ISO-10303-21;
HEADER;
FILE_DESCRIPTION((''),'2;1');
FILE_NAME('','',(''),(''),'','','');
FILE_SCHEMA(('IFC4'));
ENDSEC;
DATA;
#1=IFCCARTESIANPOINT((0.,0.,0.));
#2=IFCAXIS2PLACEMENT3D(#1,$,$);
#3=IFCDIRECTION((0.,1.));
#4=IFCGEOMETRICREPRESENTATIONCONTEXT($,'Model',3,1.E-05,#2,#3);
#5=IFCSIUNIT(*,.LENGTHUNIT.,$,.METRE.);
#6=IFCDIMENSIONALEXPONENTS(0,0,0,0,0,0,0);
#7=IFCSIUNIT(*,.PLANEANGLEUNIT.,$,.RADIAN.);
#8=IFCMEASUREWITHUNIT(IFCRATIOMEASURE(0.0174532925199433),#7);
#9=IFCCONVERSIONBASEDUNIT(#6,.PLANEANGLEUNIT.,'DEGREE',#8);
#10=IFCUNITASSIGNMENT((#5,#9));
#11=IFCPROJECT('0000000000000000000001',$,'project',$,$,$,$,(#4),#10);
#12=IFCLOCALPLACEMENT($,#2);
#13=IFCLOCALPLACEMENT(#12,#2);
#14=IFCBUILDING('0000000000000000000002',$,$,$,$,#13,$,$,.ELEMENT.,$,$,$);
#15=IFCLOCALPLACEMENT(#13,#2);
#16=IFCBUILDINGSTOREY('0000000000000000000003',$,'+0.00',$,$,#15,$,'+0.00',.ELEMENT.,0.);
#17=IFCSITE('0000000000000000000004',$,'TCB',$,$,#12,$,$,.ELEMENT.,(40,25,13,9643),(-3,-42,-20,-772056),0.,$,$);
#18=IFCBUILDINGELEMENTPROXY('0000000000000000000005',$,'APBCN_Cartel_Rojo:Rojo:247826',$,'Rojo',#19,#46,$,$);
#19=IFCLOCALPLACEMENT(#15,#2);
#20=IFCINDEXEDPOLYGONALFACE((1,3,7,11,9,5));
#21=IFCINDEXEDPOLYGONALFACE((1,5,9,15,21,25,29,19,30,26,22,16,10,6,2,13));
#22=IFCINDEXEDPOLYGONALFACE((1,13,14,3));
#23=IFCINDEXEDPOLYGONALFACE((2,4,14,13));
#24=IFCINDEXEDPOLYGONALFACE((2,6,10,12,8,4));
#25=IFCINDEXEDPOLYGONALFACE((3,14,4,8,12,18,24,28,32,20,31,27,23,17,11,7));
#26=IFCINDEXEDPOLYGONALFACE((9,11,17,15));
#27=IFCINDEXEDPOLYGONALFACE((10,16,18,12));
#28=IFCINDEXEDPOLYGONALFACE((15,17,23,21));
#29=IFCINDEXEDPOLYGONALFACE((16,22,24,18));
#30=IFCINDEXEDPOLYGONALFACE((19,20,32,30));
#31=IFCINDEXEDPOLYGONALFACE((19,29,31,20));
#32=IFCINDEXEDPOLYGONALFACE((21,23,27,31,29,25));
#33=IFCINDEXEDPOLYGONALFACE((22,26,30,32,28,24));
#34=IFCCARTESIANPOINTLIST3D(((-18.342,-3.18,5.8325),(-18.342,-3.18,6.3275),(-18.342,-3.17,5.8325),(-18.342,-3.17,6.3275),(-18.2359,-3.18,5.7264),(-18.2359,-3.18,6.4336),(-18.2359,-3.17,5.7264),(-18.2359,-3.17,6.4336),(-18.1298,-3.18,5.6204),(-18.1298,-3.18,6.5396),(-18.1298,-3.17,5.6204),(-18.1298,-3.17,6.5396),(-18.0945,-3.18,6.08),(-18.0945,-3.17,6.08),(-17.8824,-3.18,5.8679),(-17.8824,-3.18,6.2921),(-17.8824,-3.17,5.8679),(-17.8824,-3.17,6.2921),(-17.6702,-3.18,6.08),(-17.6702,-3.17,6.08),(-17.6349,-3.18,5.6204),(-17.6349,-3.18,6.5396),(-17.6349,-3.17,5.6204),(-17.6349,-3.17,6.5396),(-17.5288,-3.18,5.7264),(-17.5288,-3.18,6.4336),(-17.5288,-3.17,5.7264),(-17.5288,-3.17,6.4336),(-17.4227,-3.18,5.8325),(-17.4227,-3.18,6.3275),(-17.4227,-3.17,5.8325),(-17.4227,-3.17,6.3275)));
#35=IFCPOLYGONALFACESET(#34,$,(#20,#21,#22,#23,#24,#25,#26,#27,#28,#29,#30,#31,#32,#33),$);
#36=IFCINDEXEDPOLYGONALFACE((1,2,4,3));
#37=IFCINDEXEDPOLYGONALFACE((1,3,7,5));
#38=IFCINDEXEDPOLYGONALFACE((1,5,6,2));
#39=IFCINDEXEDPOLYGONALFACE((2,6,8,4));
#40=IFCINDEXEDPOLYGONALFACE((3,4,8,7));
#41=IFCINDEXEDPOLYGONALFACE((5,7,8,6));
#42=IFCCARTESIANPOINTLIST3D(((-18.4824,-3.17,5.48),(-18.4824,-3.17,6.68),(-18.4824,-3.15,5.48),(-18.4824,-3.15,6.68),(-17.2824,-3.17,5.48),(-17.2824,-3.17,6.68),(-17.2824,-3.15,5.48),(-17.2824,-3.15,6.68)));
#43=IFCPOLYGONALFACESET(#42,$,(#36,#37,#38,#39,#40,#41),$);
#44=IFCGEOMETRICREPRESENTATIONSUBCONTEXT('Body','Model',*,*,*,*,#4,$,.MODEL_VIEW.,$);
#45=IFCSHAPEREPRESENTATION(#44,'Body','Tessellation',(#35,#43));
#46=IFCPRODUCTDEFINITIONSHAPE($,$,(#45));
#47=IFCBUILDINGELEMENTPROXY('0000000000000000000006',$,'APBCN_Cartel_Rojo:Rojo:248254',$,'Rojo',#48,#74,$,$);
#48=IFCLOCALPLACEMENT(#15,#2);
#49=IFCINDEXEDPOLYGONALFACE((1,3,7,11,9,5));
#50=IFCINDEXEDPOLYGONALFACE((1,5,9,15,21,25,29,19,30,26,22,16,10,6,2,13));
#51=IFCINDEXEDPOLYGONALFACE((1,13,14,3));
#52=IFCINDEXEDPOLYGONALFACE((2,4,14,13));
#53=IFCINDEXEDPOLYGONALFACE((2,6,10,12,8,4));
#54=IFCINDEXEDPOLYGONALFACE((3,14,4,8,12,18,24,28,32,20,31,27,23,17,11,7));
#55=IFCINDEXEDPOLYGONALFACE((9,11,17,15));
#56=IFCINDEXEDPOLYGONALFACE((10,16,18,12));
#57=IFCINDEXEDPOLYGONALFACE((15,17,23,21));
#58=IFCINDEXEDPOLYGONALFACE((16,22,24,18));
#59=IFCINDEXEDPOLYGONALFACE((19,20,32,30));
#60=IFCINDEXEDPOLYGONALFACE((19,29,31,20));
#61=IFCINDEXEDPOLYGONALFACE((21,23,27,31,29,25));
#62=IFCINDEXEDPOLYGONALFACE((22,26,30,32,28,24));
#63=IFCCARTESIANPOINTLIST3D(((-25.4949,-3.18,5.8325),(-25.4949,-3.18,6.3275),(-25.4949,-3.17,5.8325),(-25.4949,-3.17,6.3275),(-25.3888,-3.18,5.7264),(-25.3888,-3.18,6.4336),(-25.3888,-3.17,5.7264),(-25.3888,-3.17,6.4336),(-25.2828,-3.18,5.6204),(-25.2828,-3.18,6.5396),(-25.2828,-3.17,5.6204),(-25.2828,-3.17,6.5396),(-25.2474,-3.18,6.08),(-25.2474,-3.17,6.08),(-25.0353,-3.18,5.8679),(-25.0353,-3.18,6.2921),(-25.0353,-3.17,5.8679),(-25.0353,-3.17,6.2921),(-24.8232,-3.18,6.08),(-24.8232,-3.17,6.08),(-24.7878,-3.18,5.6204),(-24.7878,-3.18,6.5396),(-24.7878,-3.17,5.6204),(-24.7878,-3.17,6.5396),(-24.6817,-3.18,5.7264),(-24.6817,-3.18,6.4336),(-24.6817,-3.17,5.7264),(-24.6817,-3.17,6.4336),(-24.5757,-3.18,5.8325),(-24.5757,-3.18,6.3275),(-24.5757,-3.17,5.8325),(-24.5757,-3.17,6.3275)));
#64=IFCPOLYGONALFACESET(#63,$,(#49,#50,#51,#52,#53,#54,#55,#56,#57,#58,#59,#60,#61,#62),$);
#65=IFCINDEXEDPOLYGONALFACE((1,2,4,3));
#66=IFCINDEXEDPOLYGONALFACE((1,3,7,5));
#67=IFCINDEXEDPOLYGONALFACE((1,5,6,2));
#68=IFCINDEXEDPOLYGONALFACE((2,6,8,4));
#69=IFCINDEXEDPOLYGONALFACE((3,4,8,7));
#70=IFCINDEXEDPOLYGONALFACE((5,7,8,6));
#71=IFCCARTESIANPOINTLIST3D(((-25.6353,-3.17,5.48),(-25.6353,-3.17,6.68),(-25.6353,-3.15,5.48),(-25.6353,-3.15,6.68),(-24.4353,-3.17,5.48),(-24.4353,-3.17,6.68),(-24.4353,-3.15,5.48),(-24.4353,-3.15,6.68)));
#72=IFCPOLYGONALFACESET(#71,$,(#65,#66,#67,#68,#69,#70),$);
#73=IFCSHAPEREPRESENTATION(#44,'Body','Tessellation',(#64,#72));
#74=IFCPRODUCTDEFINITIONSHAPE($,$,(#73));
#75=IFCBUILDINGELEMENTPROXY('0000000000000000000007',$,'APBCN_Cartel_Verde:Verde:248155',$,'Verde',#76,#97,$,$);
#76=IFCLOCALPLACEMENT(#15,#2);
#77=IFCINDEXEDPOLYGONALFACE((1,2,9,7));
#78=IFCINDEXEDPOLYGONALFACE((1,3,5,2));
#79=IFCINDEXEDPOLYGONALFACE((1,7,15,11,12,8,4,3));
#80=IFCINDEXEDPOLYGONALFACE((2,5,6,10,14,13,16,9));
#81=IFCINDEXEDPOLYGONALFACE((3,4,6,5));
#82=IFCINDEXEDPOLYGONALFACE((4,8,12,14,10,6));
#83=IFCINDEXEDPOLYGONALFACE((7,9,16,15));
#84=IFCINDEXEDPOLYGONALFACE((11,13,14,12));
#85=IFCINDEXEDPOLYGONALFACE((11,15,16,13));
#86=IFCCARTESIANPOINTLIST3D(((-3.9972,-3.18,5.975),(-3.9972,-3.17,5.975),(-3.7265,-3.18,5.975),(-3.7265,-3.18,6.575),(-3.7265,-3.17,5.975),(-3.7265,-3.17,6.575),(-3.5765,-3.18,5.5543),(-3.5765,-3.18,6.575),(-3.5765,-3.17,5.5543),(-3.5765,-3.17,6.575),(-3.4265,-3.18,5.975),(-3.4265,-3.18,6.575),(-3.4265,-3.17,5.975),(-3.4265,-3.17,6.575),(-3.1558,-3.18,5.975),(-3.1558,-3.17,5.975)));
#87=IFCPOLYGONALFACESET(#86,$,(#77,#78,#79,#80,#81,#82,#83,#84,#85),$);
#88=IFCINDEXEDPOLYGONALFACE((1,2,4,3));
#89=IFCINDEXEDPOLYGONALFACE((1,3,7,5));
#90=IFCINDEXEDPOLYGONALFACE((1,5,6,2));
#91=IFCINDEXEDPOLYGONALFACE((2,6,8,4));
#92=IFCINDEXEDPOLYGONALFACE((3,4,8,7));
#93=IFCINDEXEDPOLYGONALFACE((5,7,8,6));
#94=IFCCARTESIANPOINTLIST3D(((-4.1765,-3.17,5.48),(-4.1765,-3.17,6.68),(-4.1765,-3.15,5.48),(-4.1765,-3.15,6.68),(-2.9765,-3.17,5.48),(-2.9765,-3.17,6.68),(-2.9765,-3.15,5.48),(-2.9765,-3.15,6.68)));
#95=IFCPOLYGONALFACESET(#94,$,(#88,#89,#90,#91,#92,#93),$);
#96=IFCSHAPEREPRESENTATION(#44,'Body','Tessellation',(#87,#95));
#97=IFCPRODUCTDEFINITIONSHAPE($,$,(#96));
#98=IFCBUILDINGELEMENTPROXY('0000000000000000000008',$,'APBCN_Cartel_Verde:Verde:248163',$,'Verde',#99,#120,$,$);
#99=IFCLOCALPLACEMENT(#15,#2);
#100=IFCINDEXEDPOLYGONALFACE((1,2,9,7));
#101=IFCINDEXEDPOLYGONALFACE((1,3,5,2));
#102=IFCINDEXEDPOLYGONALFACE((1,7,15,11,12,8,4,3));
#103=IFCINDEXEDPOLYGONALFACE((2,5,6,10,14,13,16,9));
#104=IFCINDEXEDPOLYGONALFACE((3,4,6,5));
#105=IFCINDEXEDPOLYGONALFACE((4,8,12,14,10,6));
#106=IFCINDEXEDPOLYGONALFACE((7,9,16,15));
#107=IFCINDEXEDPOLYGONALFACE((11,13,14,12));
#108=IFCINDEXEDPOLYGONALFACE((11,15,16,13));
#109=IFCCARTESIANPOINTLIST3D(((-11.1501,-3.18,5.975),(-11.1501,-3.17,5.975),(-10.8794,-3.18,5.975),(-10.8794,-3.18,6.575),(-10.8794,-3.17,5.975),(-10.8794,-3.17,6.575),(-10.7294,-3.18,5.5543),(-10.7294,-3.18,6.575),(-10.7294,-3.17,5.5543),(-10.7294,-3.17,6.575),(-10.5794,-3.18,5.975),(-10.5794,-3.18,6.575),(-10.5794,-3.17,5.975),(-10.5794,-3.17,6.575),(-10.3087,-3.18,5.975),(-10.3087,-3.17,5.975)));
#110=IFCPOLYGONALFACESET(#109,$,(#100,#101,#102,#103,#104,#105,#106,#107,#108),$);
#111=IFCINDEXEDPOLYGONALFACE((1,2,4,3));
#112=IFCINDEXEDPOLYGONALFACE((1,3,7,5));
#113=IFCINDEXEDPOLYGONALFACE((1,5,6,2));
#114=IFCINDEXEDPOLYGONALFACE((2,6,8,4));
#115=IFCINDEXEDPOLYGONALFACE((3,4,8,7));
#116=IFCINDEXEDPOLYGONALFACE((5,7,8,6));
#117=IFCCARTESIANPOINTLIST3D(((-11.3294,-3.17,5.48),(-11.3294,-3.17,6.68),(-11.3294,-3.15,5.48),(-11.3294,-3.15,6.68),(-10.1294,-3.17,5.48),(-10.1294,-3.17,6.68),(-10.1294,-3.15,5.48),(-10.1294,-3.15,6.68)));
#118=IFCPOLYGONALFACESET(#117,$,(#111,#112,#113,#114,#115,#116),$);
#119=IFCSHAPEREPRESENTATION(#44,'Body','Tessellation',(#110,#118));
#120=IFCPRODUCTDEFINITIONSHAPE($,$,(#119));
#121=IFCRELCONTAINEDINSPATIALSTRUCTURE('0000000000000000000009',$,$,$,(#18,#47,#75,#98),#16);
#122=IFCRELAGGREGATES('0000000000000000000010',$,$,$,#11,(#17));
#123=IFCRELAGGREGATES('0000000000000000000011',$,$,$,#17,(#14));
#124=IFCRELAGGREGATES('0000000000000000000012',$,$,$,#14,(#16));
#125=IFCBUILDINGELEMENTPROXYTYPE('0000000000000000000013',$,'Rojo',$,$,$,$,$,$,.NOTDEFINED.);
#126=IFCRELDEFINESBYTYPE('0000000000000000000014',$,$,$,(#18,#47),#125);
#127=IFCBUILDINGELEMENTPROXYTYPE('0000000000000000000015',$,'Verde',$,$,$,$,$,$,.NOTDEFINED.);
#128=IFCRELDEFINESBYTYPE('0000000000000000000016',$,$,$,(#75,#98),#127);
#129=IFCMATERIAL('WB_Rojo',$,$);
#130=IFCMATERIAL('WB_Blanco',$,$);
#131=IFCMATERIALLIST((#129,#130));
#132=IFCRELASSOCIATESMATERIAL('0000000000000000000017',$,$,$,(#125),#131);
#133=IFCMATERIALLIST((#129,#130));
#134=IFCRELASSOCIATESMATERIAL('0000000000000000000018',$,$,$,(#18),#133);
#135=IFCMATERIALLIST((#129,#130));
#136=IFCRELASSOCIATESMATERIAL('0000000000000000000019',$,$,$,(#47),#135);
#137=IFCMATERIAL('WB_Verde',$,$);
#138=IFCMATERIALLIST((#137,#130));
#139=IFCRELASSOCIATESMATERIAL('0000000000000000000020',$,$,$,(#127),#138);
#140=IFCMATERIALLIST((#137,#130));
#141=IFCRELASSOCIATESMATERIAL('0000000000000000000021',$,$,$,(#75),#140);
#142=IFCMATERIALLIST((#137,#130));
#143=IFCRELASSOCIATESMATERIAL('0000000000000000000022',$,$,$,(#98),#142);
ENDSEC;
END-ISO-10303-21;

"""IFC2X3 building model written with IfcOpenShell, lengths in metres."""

from ifc_helpers import new_model, entity, si_unit, converted_unit, direction, frame, origin, origin_2d_with_axis, place, context, subcontext, project, spatial, polyline, rectangle, outline, extrude, source, transform, mapped, material, material_list, type_object, type_shapes, element, save


model = new_model("IFC2X3")

# Units and contexts
model_context = context("Model", 3, precision=1e-05, world=origin(), true_north=direction((0.0, 1.0)))
body_context = subcontext(model_context, "Body", "Model", "MODEL_VIEW")
ifc_project = project(units=[si_unit("LENGTHUNIT", "METRE"), converted_unit("PLANEANGLEUNIT", "DEGREE", entity("IfcRatioMeasure", 0.0174532925199433), si_unit("PLANEANGLEUNIT", "RADIAN"), dimensions=[0, 0, 0, 0, 0, 0, 0])], contexts=[model_context])

# Site, building, storey
site_placement = place(None, origin())
site = spatial("IfcSite", under=ifc_project, at=site_placement, Name="TCB", CompositionType="ELEMENT", RefLatitude=(40, 25, 13, 9643), RefLongitude=(-3, -42, -20, -772056), RefElevation=0.0)
building_placement = place(site_placement, origin())
building = spatial("IfcBuilding", under=site, at=building_placement, CompositionType="ELEMENT")
storey_placement = place(building_placement, origin())
storey = spatial("IfcBuildingStorey", under=building, at=storey_placement, Name="+0.00", LongName="+0.00", CompositionType="ELEMENT", Elevation=0.0)

# Building element proxies
ifc_material_1 = material(Name="WB_Rojo")
ifc_material_2 = material(Name="WB_Blanco")
ifc_material_list_1 = material_list([ifc_material_1, ifc_material_2])
ifc_material_list_2 = material_list([ifc_material_1, ifc_material_2])
building_element_proxy_type_1 = type_object("IfcBuildingElementProxyType", Name="Rojo", PredefinedType="NOTDEFINED", material=ifc_material_list_2)
shared_shape_1 = source(origin(), body_context, "Body", "SweptSolid", [
    extrude(outline(polyline([(-0.15, -0.5), (0.0, -0.5), (0.15, -0.5), (0.15, -0.15), (0.5, -0.15), (0.5, 0.0), (0.5, 0.15), (0.15, 0.15), (0.15, 0.5), (0.0, 0.5), (-0.15, 0.5), (-0.15, 0.15), (-0.5, 0.15), (-0.5, 0.0), (-0.5, -0.15), (-0.15, -0.15), (-0.15, -0.5)])), frame((0.0, 0.0, 0.02), z_axis=(0.0, 0.0, 1.0), x_axis=(-0.707107, 0.707107, 0.0)), (0.0, 0.0, 1.0), 0.01),
    extrude(rectangle(XDim=1.2, YDim=1.2, at=origin_2d_with_axis()), origin(), (0.0, 0.0, 1.0), 0.02),
])
type_shapes(building_element_proxy_type_1, [shared_shape_1])
proxy_1_placement = place(storey_placement, frame((-17.8824, -3.15, 6.08), z_axis=(0.0, -1.0, 0.0), x_axis=(1.0, 0.0, 0.0)))
element("IfcBuildingElementProxy", 1, at=proxy_1_placement, inside=storey, type_object=building_element_proxy_type_1, material=ifc_material_list_1, Name="APBCN_Cartel_Rojo:Rojo:247826", ObjectType="Rojo", context=body_context, shape_type="MappedRepresentation", body=[
    mapped(shared_shape_1, transform((0.0, 0.0, 0.0), scale=1.0)),
])
ifc_material_list_3 = material_list([ifc_material_1, ifc_material_2])
proxy_2_placement = place(storey_placement, frame((-25.0353, -3.15, 6.08), z_axis=(0.0, -1.0, 0.0), x_axis=(1.0, 0.0, 0.0)))
element("IfcBuildingElementProxy", 2, at=proxy_2_placement, inside=storey, type_object=building_element_proxy_type_1, material=ifc_material_list_3, Name="APBCN_Cartel_Rojo:Rojo:248254", ObjectType="Rojo", context=body_context, shape_type="MappedRepresentation", body=[
    mapped(shared_shape_1, transform((0.0, 0.0, 0.0), scale=1.0)),
])
ifc_material_3 = material(Name="WB_Verde")
ifc_material_list_4 = material_list([ifc_material_3, ifc_material_2])
ifc_material_list_5 = material_list([ifc_material_3, ifc_material_2])
building_element_proxy_type_2 = type_object("IfcBuildingElementProxyType", Name="Verde", PredefinedType="NOTDEFINED", material=ifc_material_list_5)
shared_shape_2 = source(origin(), body_context, "Body", "SweptSolid", [
    extrude(outline(polyline([(-0.15, -0.4276), (0.0, -0.4276), (0.15, -0.4276), (0.15, 0.1724), (0.4207, 0.1724), (0.0, 0.5931), (-0.4207, 0.1724), (-0.15, 0.1724), (-0.15, -0.4276)])), frame((0.0, 0.0674, 0.02), z_axis=(0.0, 0.0, 1.0), x_axis=(-1.0, 0.0, 0.0)), (0.0, 0.0, 1.0), 0.01),
    extrude(rectangle(XDim=1.2, YDim=1.2, at=origin_2d_with_axis()), origin(), (0.0, 0.0, 1.0), 0.02),
])
type_shapes(building_element_proxy_type_2, [shared_shape_2])
proxy_3_placement = place(storey_placement, frame((-3.5765, -3.15, 6.08), z_axis=(0.0, -1.0, 0.0), x_axis=(1.0, 0.0, 0.0)))
element("IfcBuildingElementProxy", 3, at=proxy_3_placement, inside=storey, type_object=building_element_proxy_type_2, material=ifc_material_list_4, Name="APBCN_Cartel_Verde:Verde:248155", ObjectType="Verde", context=body_context, shape_type="MappedRepresentation", body=[
    mapped(shared_shape_2, transform((0.0, 0.0, 0.0), scale=1.0)),
])
ifc_material_list_6 = material_list([ifc_material_3, ifc_material_2])
proxy_4_placement = place(storey_placement, frame((-10.7294, -3.15, 6.08), z_axis=(0.0, -1.0, 0.0), x_axis=(1.0, 0.0, 0.0)))
element("IfcBuildingElementProxy", 4, at=proxy_4_placement, inside=storey, type_object=building_element_proxy_type_2, material=ifc_material_list_6, Name="APBCN_Cartel_Verde:Verde:248163", ObjectType="Verde", context=body_context, shape_type="MappedRepresentation", body=[
    mapped(shared_shape_2, transform((0.0, 0.0, 0.0), scale=1.0)),
])

save(model, "model.ifc")
